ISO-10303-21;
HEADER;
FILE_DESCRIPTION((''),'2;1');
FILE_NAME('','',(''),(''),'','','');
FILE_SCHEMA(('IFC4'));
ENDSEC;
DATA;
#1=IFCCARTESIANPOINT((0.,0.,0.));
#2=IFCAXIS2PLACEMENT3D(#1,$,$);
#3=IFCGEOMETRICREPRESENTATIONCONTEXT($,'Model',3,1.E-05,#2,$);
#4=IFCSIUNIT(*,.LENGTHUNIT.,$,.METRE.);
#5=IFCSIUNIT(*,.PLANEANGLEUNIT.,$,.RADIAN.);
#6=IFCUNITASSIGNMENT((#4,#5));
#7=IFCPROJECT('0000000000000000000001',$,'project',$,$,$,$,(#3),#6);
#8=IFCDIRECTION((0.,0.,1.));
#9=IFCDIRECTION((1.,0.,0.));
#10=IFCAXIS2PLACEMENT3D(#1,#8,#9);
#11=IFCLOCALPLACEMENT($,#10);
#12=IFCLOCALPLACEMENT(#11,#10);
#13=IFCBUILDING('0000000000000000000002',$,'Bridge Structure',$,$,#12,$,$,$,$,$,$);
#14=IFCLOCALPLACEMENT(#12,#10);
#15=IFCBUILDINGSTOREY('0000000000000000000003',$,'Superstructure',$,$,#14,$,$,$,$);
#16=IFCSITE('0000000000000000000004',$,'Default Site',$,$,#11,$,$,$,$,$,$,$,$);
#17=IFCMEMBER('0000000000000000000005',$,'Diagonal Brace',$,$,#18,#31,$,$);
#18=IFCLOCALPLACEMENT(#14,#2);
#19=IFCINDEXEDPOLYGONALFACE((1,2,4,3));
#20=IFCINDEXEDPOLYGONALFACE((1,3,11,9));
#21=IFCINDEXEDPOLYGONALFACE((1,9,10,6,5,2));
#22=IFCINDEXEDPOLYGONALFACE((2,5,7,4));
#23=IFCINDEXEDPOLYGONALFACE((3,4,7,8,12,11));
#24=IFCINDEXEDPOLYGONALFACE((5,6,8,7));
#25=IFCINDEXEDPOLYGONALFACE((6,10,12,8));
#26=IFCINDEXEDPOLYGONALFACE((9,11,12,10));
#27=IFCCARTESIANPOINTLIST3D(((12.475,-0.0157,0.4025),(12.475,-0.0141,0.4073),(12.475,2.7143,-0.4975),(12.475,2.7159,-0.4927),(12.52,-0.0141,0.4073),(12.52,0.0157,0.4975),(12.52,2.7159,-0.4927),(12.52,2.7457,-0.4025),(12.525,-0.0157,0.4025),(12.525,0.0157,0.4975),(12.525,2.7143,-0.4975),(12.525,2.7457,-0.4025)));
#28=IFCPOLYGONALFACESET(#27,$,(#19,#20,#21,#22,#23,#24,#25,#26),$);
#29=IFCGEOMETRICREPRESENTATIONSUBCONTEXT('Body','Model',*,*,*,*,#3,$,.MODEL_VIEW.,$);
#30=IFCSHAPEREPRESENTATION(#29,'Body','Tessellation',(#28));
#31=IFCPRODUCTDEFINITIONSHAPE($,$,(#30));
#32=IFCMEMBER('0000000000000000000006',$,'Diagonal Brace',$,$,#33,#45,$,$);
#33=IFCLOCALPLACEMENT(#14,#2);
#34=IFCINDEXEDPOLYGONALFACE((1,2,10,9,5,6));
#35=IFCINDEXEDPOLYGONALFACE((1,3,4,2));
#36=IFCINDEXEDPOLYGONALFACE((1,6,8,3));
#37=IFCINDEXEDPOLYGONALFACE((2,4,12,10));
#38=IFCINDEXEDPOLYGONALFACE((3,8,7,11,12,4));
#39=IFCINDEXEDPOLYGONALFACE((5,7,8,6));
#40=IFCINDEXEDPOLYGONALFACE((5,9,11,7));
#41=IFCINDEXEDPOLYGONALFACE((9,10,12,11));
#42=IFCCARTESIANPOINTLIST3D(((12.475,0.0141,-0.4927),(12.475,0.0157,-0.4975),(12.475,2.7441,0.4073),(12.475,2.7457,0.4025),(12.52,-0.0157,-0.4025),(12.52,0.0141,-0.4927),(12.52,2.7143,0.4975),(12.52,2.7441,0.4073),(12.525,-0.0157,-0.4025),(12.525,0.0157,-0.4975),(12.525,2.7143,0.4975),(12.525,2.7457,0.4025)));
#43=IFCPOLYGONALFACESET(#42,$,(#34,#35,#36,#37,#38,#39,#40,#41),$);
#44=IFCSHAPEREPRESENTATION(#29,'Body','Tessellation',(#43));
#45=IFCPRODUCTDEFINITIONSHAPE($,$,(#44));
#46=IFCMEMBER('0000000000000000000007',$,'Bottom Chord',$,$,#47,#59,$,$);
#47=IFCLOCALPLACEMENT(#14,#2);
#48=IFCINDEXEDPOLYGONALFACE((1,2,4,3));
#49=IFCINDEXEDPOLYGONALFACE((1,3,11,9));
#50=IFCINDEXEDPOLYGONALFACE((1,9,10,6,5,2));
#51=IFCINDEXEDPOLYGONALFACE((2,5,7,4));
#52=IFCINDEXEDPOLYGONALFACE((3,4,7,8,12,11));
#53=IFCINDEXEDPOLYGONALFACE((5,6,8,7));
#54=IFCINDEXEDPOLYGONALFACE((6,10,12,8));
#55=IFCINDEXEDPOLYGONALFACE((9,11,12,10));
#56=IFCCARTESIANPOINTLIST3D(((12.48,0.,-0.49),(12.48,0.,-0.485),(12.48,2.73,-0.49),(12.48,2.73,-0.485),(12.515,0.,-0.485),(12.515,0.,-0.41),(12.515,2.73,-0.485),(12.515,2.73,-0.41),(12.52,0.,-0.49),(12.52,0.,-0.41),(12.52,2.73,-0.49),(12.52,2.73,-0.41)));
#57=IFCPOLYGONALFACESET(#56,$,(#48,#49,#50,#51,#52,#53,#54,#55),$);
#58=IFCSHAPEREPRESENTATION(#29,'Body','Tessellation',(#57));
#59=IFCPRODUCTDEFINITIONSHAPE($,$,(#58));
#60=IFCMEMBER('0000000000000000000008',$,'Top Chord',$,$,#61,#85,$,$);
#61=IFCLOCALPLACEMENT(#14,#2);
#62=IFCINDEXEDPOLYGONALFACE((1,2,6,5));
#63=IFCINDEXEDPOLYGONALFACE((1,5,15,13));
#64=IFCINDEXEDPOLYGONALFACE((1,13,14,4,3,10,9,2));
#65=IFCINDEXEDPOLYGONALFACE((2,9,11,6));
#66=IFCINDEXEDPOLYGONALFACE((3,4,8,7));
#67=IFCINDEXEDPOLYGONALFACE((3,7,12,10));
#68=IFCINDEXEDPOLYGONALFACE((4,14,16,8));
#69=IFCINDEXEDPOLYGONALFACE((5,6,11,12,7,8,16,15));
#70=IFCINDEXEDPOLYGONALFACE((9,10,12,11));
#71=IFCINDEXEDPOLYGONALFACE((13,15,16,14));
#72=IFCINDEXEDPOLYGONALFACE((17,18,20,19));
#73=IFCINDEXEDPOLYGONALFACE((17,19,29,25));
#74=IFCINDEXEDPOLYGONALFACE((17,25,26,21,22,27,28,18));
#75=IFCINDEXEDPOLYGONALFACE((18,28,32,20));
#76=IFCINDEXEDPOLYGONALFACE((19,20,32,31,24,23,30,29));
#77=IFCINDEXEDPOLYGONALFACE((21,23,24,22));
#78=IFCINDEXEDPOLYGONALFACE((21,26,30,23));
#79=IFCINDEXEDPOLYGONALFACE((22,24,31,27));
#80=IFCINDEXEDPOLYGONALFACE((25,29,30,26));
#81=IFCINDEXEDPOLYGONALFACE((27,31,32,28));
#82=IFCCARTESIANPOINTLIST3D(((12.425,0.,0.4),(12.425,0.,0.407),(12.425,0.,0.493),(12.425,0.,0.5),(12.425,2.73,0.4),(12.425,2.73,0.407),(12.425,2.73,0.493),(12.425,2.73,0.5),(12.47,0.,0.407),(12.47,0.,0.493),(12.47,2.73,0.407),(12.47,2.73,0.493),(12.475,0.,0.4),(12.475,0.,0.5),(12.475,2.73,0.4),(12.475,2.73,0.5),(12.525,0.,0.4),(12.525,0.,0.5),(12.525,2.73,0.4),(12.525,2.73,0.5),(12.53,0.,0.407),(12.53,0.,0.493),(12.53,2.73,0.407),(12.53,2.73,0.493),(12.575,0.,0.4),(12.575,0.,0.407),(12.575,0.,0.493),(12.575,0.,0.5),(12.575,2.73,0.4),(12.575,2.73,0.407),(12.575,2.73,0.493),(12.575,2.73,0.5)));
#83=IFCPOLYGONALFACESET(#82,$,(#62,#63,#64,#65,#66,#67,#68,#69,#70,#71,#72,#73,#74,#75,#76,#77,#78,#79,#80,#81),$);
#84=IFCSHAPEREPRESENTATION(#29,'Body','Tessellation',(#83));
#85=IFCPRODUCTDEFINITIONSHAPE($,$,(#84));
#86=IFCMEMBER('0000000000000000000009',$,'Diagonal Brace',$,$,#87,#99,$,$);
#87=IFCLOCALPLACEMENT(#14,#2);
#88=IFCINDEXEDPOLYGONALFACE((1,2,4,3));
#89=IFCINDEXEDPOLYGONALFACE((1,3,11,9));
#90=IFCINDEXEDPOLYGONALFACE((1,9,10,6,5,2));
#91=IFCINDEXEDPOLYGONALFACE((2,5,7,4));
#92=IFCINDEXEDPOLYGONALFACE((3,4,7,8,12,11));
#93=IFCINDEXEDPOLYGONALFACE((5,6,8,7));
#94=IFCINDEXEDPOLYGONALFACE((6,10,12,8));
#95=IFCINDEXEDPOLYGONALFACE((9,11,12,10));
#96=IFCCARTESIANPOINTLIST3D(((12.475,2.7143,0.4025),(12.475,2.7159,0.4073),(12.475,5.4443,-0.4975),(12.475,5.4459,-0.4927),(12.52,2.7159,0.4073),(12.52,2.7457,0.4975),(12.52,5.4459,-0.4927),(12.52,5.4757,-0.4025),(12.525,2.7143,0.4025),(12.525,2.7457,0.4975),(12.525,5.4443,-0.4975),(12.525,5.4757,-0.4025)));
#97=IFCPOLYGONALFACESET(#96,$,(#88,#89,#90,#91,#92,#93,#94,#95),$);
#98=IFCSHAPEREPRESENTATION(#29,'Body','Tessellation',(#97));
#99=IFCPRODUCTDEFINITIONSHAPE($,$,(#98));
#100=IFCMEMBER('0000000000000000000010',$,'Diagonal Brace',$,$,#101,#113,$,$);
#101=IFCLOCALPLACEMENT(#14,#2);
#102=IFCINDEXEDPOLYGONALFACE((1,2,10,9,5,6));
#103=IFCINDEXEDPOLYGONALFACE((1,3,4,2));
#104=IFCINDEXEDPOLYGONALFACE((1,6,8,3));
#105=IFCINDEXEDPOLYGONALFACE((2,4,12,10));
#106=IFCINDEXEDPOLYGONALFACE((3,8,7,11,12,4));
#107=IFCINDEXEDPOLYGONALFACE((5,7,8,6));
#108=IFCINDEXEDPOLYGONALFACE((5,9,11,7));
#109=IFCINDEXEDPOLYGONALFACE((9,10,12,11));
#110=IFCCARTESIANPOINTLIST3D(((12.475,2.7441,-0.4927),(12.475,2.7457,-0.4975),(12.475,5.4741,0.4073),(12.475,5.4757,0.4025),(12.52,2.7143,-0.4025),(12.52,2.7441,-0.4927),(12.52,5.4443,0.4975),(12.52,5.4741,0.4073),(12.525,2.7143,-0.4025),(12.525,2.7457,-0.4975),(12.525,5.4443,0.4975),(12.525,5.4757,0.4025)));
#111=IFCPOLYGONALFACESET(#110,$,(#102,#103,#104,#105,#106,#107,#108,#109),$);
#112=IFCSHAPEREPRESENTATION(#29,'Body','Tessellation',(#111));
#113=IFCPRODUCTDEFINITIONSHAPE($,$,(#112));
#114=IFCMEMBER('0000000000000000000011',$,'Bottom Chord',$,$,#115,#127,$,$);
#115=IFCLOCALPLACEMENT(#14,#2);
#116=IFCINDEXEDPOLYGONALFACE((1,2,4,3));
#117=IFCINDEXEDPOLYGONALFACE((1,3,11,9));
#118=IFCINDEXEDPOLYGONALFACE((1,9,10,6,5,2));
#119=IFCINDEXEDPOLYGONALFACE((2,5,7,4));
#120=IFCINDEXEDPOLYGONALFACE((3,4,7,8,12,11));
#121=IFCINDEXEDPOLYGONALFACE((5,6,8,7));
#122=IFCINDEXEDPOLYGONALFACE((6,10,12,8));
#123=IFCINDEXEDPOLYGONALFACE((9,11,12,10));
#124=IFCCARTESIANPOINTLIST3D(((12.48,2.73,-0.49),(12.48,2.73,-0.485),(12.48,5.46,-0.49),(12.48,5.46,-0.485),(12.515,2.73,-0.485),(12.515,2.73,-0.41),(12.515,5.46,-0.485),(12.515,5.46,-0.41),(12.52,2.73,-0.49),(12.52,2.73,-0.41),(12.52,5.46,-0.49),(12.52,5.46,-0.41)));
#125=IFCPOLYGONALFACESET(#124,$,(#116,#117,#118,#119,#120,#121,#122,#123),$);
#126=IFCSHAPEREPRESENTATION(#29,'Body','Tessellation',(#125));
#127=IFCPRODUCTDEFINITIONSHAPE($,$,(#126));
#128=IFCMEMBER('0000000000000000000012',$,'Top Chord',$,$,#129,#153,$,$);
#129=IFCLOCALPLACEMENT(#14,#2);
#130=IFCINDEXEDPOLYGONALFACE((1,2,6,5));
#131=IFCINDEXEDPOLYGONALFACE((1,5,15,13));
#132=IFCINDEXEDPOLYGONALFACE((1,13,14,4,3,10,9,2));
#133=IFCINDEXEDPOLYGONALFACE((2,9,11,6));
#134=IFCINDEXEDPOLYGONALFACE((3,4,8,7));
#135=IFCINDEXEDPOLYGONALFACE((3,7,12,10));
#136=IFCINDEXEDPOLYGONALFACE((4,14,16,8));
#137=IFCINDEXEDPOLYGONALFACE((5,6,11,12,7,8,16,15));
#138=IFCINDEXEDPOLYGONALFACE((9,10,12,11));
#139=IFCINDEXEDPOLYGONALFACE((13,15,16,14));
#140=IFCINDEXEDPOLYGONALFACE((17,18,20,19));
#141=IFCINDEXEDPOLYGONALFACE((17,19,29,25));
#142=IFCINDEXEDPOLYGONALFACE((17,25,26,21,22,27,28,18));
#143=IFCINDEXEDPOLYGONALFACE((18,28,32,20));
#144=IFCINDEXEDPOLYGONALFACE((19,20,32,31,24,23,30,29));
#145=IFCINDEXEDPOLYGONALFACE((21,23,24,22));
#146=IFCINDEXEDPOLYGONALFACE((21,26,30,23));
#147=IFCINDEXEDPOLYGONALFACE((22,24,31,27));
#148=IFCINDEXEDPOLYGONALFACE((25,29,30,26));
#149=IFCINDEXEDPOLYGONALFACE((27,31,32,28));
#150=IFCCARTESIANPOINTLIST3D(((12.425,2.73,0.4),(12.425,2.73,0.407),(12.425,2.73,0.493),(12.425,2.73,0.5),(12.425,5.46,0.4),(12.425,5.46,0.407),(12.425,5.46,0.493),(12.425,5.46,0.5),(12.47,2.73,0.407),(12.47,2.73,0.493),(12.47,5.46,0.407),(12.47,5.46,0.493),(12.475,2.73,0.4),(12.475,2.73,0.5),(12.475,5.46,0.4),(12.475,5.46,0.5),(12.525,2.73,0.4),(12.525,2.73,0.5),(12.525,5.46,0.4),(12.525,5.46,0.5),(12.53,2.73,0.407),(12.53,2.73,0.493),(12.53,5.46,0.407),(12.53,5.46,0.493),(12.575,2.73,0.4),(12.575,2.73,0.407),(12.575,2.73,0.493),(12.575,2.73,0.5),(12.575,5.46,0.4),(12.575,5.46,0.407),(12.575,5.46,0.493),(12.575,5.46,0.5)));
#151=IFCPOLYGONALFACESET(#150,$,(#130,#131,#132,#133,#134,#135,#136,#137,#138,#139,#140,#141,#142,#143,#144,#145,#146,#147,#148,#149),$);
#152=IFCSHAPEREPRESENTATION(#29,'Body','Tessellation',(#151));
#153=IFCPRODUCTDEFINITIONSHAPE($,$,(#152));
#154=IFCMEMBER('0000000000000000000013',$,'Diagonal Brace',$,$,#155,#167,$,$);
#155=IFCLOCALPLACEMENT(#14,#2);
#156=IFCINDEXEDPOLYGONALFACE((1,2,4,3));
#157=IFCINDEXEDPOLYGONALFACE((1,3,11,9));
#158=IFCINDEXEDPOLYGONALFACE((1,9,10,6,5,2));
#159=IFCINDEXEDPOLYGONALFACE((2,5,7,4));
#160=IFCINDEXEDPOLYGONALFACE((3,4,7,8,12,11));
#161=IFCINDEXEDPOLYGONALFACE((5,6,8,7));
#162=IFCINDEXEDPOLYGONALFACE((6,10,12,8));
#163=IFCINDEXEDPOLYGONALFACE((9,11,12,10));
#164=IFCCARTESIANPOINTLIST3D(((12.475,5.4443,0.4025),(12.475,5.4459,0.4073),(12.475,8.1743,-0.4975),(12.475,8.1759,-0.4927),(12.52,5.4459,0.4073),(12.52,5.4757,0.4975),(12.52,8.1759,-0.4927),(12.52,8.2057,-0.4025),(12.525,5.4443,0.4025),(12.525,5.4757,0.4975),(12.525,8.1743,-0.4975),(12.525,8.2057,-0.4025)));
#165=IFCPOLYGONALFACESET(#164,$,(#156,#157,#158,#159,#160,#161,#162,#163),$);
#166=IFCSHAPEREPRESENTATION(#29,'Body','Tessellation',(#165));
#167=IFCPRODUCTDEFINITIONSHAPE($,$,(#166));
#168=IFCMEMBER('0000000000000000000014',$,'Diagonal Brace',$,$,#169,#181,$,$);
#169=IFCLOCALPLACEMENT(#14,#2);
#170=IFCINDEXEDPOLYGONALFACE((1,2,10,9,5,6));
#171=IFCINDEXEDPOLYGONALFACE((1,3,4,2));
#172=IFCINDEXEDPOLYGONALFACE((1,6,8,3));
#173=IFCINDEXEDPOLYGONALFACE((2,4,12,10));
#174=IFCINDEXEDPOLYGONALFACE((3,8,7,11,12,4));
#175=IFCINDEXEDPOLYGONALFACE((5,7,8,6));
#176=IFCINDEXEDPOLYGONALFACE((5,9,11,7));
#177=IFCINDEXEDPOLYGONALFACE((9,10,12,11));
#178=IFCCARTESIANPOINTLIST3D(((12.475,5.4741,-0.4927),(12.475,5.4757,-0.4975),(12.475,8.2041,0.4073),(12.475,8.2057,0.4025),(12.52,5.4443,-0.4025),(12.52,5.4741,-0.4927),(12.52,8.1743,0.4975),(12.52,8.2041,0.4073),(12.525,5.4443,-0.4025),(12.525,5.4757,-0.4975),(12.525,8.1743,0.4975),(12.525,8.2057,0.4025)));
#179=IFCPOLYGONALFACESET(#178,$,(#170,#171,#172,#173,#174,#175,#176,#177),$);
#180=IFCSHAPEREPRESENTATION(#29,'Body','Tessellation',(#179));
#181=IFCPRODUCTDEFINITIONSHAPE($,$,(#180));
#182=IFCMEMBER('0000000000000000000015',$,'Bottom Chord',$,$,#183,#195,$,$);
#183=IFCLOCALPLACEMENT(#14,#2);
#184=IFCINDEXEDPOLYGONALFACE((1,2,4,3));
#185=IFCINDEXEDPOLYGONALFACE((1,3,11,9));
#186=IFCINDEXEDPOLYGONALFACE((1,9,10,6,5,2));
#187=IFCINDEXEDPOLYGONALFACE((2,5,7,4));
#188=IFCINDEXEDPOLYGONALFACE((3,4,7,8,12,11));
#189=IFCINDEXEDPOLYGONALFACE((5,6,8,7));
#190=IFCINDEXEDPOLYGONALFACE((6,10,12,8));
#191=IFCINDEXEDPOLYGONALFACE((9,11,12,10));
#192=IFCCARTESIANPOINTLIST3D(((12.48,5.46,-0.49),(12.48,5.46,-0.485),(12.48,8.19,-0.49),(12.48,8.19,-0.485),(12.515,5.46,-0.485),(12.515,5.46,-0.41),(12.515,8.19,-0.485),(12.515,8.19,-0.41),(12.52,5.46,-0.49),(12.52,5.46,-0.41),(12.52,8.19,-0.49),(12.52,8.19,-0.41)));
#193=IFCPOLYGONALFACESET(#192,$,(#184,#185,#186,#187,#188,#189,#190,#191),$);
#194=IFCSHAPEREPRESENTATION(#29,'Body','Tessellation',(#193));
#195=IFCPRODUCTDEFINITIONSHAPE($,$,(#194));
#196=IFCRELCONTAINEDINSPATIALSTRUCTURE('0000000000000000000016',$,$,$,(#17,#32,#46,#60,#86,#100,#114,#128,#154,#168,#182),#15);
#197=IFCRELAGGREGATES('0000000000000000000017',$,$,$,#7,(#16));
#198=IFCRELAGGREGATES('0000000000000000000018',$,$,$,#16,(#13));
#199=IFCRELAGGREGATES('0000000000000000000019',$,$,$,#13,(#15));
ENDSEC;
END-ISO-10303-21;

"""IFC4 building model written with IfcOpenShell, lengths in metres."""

from ifc_helpers import new_model, si_unit, frame, origin, origin_with_axes, origin_2d_with_axis, place, context, subcontext, project, spatial, polyline, l_section, outline, composite_profile, extrude, element, save


model = new_model("IFC4")

# Units and contexts
model_context = context("Model", 3, precision=1e-05, world=origin())
body_context = subcontext(model_context, "Body", "Model", "MODEL_VIEW")
ifc_project = project(units=[si_unit("LENGTHUNIT", "METRE"), si_unit("PLANEANGLEUNIT", "RADIAN")], contexts=[model_context])

# Site, building, storey
site_placement = place(None, origin_with_axes())
site = spatial("IfcSite", under=ifc_project, at=site_placement, Name="Default Site")
building_placement = place(site_placement, origin_with_axes())
building = spatial("IfcBuilding", under=site, at=building_placement, Name="Bridge Structure")
storey_placement = place(building_placement, origin_with_axes())
storey = spatial("IfcBuildingStorey", under=building, at=storey_placement, Name="Superstructure")

# Members
for number, where, z_axis, x_axis, name in (
    (1, (12.5, 0.0, 0.45), (0.0, 0.949722, -0.313095), (-1.0, 0.0, 0.0), "Diagonal Brace"),
    (2, (12.5, 0.0, -0.45), (0.0, 0.949722, 0.313095), (-1.0, 0.0, 0.0), "Diagonal Brace"),
):
    element("IfcMember", number, at=place(storey_placement, frame(where, z_axis=z_axis, x_axis=x_axis)), inside=storey, Name=name, context=body_context, shape_type="SweptSolid", body=[
        extrude(l_section(Depth=0.1, Width=0.05, Thickness=0.005, at=origin_2d_with_axis()), origin_with_axes(), (0.0, 0.0, 1.0), 2.8745),
    ])
member_1_placement = place(storey_placement, frame((12.5, 0.0, -0.45), z_axis=(0.0, 1.0, 0.0), x_axis=(-1.0, 0.0, 0.0)))
element("IfcMember", 3, at=member_1_placement, inside=storey, Name="Bottom Chord", context=body_context, shape_type="SweptSolid", body=[
    extrude(l_section(Depth=0.08, Width=0.04, Thickness=0.005, at=origin_2d_with_axis()), origin_with_axes(), (0.0, 0.0, 1.0), 2.73),
])
member_2_placement = place(storey_placement, frame((12.5, 0.0, 0.45), z_axis=(0.0, 1.0, 0.0), x_axis=(-1.0, 0.0, 0.0)))
element("IfcMember", 4, at=member_2_placement, inside=storey, Name="Top Chord", context=body_context, shape_type="SweptSolid", body=[
    extrude(composite_profile([outline(polyline([(-0.025, -0.05), (-0.025, 0.05), (-0.075, 0.05), (-0.075, 0.043), (-0.03, 0.043), (-0.03, -0.043), (-0.075, -0.043), (-0.075, -0.05), (-0.025, -0.05)])), outline(polyline([(0.025, -0.05), (0.075, -0.05), (0.075, -0.043), (0.03, -0.043), (0.03, 0.043), (0.075, 0.043), (0.075, 0.05), (0.025, 0.05), (0.025, -0.05)]))]), origin_with_axes(), (0.0, 0.0, 1.0), 2.73),
])
for number, where, z_axis, x_axis, name in (
    (5, (12.5, 2.73, 0.45), (0.0, 0.949722, -0.313095), (-1.0, 0.0, 0.0), "Diagonal Brace"),
    (6, (12.5, 2.73, -0.45), (0.0, 0.949722, 0.313095), (-1.0, 0.0, 0.0), "Diagonal Brace"),
):
    element("IfcMember", number, at=place(storey_placement, frame(where, z_axis=z_axis, x_axis=x_axis)), inside=storey, Name=name, context=body_context, shape_type="SweptSolid", body=[
        extrude(l_section(Depth=0.1, Width=0.05, Thickness=0.005, at=origin_2d_with_axis()), origin_with_axes(), (0.0, 0.0, 1.0), 2.8745),
    ])
member_3_placement = place(storey_placement, frame((12.5, 2.73, -0.45), z_axis=(0.0, 1.0, 0.0), x_axis=(-1.0, 0.0, 0.0)))
element("IfcMember", 7, at=member_3_placement, inside=storey, Name="Bottom Chord", context=body_context, shape_type="SweptSolid", body=[
    extrude(l_section(Depth=0.08, Width=0.04, Thickness=0.005, at=origin_2d_with_axis()), origin_with_axes(), (0.0, 0.0, 1.0), 2.73),
])
member_4_placement = place(storey_placement, frame((12.5, 2.73, 0.45), z_axis=(0.0, 1.0, 0.0), x_axis=(-1.0, 0.0, 0.0)))
element("IfcMember", 8, at=member_4_placement, inside=storey, Name="Top Chord", context=body_context, shape_type="SweptSolid", body=[
    extrude(composite_profile([outline(polyline([(-0.025, -0.05), (-0.025, 0.05), (-0.075, 0.05), (-0.075, 0.043), (-0.03, 0.043), (-0.03, -0.043), (-0.075, -0.043), (-0.075, -0.05), (-0.025, -0.05)])), outline(polyline([(0.025, -0.05), (0.075, -0.05), (0.075, -0.043), (0.03, -0.043), (0.03, 0.043), (0.075, 0.043), (0.075, 0.05), (0.025, 0.05), (0.025, -0.05)]))]), origin_with_axes(), (0.0, 0.0, 1.0), 2.73),
])
for number, where, z_axis, x_axis, name in (
    (9, (12.5, 5.46, 0.45), (0.0, 0.949722, -0.313095), (-1.0, 0.0, 0.0), "Diagonal Brace"),
    (10, (12.5, 5.46, -0.45), (0.0, 0.949722, 0.313095), (-1.0, 0.0, 0.0), "Diagonal Brace"),
):
    element("IfcMember", number, at=place(storey_placement, frame(where, z_axis=z_axis, x_axis=x_axis)), inside=storey, Name=name, context=body_context, shape_type="SweptSolid", body=[
        extrude(l_section(Depth=0.1, Width=0.05, Thickness=0.005, at=origin_2d_with_axis()), origin_with_axes(), (0.0, 0.0, 1.0), 2.8745),
    ])
member_5_placement = place(storey_placement, frame((12.5, 5.46, -0.45), z_axis=(0.0, 1.0, 0.0), x_axis=(-1.0, 0.0, 0.0)))
element("IfcMember", 11, at=member_5_placement, inside=storey, Name="Bottom Chord", context=body_context, shape_type="SweptSolid", body=[
    extrude(l_section(Depth=0.08, Width=0.04, Thickness=0.005, at=origin_2d_with_axis()), origin_with_axes(), (0.0, 0.0, 1.0), 2.73),
])

save(model, "model.ifc")
